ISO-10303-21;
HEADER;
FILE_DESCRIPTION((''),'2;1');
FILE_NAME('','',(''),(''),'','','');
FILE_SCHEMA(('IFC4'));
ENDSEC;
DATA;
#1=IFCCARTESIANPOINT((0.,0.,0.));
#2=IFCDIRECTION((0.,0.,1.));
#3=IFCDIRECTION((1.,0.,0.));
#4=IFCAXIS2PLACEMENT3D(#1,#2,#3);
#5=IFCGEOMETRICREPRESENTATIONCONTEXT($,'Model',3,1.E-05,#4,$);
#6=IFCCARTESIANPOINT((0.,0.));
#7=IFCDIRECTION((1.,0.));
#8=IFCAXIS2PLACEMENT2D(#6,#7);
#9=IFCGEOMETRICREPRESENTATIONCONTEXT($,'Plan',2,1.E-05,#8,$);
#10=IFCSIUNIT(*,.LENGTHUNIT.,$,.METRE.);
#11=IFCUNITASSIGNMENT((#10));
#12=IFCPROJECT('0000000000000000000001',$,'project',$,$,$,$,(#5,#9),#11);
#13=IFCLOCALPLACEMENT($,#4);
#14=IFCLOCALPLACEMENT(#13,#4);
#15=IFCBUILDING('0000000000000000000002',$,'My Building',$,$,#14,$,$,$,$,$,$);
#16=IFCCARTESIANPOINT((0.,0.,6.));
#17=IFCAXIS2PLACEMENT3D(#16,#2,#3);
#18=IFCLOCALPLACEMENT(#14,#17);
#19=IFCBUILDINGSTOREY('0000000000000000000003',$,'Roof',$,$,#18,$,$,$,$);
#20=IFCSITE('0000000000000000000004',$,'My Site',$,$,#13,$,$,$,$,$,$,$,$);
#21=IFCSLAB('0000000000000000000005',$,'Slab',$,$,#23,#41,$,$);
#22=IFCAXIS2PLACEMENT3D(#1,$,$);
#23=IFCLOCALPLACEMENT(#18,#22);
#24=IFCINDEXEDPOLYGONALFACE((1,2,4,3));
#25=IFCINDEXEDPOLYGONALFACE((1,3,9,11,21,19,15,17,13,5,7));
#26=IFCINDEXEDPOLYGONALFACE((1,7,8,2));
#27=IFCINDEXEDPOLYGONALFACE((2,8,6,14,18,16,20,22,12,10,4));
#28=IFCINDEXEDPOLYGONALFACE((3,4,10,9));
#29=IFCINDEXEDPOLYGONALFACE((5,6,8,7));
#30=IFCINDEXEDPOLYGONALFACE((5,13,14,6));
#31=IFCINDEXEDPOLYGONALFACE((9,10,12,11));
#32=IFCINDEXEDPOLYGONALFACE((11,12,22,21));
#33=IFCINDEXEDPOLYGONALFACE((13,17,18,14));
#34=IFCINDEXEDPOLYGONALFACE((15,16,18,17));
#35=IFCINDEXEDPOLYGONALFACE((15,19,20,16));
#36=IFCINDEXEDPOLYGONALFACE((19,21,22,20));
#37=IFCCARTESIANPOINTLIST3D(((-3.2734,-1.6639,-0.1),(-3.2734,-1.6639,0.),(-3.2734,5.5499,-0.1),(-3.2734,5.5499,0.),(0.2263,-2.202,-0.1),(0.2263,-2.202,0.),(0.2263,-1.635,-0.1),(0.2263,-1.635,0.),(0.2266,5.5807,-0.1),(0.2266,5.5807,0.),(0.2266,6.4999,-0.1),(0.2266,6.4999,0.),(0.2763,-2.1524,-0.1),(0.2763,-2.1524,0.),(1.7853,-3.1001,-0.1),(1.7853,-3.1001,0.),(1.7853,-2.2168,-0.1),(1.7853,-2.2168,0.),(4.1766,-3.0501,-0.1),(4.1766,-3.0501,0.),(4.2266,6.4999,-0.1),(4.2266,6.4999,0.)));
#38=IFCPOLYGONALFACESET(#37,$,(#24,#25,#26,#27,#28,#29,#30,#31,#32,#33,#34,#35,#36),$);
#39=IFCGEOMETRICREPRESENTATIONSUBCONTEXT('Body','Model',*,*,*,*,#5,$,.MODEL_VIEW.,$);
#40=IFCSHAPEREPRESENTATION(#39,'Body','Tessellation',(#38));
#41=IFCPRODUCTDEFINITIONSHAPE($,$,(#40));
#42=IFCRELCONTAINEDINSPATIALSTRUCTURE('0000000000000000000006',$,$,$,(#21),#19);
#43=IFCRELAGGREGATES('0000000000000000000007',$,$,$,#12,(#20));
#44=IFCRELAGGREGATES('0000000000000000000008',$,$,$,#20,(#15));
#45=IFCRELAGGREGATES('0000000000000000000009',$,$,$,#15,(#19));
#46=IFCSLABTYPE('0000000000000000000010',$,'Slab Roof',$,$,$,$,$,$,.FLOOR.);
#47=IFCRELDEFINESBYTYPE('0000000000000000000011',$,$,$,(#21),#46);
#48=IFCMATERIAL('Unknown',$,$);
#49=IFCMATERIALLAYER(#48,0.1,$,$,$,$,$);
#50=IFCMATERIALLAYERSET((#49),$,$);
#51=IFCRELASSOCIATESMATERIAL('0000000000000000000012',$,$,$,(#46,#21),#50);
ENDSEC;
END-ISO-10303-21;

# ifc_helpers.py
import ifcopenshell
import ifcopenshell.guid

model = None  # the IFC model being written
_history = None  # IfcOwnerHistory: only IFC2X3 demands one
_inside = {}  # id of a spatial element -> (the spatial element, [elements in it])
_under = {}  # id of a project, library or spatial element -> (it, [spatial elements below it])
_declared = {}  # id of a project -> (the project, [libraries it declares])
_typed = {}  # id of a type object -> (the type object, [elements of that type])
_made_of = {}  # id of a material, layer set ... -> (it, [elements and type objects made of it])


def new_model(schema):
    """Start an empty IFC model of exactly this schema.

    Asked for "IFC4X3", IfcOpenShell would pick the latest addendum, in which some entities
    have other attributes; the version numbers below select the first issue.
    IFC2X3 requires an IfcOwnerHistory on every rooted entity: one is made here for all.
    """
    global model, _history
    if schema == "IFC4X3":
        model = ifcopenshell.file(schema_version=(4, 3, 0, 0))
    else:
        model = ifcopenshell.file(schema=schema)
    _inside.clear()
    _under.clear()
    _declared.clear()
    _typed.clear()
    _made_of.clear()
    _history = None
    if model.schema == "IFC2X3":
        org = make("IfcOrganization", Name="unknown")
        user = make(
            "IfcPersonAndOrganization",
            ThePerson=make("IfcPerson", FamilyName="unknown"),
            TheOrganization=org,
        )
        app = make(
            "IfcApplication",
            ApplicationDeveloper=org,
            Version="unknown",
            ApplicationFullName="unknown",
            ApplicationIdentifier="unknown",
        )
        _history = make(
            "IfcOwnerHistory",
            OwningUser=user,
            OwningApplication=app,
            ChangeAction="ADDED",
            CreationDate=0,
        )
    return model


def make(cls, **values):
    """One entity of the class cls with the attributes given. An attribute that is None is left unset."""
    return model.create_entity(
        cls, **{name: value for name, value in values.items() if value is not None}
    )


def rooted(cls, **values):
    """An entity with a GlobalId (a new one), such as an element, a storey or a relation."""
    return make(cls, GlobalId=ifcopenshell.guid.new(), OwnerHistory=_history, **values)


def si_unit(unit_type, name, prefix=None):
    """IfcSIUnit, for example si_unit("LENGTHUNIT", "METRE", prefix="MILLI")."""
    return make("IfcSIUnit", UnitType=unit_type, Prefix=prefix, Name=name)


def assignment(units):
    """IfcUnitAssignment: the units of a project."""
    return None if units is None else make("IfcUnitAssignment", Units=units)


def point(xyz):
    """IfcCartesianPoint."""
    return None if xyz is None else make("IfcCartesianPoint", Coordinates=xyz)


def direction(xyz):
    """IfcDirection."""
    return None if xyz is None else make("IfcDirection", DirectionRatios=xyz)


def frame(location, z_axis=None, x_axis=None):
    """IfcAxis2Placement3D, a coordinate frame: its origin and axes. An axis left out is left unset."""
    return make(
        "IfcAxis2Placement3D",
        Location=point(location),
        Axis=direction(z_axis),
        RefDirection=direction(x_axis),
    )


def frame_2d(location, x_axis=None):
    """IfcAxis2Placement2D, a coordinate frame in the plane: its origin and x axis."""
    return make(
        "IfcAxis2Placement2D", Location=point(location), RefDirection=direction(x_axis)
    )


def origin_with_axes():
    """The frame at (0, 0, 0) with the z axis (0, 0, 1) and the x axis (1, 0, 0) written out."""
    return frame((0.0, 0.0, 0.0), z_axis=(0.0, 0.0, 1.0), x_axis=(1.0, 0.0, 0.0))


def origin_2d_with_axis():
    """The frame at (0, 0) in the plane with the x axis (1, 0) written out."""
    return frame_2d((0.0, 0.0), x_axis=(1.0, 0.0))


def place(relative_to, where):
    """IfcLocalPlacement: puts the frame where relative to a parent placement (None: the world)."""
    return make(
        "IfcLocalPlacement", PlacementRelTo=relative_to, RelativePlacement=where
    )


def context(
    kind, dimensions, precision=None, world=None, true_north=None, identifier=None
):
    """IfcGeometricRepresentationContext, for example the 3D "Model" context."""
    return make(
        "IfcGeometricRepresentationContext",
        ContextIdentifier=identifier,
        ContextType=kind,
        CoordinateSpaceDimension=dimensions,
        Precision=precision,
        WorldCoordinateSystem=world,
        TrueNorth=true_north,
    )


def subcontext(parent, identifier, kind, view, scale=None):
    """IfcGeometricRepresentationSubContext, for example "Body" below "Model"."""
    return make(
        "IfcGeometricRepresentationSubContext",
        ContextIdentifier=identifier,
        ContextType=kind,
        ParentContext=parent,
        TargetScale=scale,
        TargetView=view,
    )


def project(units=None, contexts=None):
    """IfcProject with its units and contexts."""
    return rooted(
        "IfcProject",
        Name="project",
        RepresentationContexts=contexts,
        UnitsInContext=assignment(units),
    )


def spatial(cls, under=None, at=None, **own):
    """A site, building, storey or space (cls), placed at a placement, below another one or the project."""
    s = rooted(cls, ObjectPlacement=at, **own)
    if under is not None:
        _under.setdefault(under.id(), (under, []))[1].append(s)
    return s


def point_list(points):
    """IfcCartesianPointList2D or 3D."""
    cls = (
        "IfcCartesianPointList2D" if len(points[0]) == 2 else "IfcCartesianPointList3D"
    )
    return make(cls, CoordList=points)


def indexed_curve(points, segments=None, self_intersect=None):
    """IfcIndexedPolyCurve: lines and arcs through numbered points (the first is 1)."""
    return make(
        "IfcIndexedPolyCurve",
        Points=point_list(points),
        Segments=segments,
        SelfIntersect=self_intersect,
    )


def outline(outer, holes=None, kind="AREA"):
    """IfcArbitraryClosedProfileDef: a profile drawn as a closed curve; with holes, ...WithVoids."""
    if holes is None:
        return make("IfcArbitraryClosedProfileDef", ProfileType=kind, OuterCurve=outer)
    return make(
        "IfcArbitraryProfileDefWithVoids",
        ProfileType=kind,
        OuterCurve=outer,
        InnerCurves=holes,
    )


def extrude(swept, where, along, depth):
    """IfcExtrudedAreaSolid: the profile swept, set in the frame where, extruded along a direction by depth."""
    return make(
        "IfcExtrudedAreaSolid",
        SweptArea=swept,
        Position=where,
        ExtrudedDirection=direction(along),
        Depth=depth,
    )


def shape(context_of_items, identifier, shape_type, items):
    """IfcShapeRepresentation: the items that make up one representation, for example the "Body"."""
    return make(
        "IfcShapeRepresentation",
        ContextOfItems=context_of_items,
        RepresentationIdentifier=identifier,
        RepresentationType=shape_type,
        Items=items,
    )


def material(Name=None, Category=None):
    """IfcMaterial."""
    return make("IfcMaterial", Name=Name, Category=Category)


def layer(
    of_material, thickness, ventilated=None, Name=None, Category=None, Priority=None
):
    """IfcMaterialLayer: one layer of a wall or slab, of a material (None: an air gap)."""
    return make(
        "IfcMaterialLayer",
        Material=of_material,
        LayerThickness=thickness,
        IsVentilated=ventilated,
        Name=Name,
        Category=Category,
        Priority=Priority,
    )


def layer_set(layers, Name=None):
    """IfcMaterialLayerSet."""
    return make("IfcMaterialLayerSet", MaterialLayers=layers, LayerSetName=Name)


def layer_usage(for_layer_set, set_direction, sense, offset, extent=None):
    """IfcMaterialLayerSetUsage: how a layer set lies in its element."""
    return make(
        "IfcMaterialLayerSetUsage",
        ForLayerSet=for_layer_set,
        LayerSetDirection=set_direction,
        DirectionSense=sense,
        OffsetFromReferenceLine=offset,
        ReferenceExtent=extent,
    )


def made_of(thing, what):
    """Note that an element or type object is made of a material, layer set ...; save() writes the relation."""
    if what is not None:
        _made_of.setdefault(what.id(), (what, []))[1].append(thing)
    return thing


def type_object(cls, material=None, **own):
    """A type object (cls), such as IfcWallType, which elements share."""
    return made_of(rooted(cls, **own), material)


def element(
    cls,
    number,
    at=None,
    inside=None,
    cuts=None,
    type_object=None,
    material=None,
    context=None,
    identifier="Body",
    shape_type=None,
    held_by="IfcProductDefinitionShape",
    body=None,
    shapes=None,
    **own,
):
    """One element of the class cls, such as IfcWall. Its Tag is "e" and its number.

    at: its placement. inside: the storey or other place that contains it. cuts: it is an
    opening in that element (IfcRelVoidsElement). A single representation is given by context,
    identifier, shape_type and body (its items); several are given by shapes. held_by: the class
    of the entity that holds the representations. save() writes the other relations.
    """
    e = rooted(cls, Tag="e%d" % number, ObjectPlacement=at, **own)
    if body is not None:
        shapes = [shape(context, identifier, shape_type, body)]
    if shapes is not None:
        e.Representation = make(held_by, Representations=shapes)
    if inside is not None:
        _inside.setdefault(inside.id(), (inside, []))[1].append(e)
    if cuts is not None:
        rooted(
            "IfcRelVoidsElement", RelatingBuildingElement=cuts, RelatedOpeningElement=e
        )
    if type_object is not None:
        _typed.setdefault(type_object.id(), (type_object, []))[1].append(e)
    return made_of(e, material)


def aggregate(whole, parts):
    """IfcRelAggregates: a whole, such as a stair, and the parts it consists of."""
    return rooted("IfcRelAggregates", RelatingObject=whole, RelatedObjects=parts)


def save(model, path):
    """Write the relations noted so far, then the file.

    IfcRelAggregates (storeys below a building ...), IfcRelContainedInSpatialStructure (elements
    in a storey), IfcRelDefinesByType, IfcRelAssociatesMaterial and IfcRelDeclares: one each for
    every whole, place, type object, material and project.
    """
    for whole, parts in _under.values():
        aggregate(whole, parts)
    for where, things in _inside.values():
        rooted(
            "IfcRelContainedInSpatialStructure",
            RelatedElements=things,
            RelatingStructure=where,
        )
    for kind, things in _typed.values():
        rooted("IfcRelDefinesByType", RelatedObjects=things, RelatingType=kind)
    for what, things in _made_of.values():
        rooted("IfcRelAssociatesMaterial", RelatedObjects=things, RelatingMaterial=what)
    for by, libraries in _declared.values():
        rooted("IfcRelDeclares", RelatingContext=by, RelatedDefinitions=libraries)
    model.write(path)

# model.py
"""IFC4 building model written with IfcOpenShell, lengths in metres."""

from ifc_helpers import new_model, si_unit, frame, origin_with_axes, origin_2d_with_axis, place, context, subcontext, project, spatial, indexed_curve, outline, extrude, material, layer, layer_set, layer_usage, type_object, element, save


model = new_model("IFC4")

# Units and contexts
model_context = context("Model", 3, precision=1e-05, world=origin_with_axes())
plan_context = context("Plan", 2, precision=1e-05, world=origin_2d_with_axis())
body_context = subcontext(model_context, "Body", "Model", "MODEL_VIEW")
ifc_project = project(units=[si_unit("LENGTHUNIT", "METRE")], contexts=[model_context, plan_context])

# Site, building, storey
site_placement = place(None, origin_with_axes())
site = spatial("IfcSite", under=ifc_project, at=site_placement, Name="My Site")
building_placement = place(site_placement, origin_with_axes())
building = spatial("IfcBuilding", under=site, at=building_placement, Name="My Building")
storey_placement = place(building_placement, frame((0.0, 0.0, 6.0), z_axis=(0.0, 0.0, 1.0), x_axis=(1.0, 0.0, 0.0)))
storey = spatial("IfcBuildingStorey", under=building, at=storey_placement, Name="Roof")

# Slab
ifc_material = material(Name="Unknown")
ifc_layer = layer(ifc_material, 0.1)
ifc_layer_set = layer_set([ifc_layer])
ifc_layer_usage = layer_usage(ifc_layer_set, "AXIS3", "POSITIVE", -0.1)
slab_type = type_object("IfcSlabType", Name="Slab Roof", PredefinedType="FLOOR", material=ifc_layer_set)
slab_placement = place(storey_placement, frame((0.2763, -2.1524, 0.0), z_axis=(0.0, 0.0, 1.0), x_axis=(1.0, 0.0, 0.0)))
element("IfcSlab", 1, at=slab_placement, inside=storey, type_object=slab_type, material=ifc_layer_usage, Name="Slab", context=body_context, shape_type="SweptSolid", body=[
    extrude(outline(indexed_curve([(0.0, 0.0), (1.509, -0.0643), (1.509, -0.9477), (3.9003, -0.8977), (3.9503, 8.6523), (-0.0497, 8.6523), (-0.0497, 7.7331), (-3.5497, 7.7023), (-3.5497, 0.4886), (-0.05, 0.5174), (-0.05, -0.0495), (0.0, 0.0)])), frame((0.0, 0.0, -0.1), z_axis=(0.0, 0.0, 1.0), x_axis=(1.0, 0.0, 0.0)), (0.0, 0.0, 1.0), 0.1),
])

save(model, "model.ifc")
